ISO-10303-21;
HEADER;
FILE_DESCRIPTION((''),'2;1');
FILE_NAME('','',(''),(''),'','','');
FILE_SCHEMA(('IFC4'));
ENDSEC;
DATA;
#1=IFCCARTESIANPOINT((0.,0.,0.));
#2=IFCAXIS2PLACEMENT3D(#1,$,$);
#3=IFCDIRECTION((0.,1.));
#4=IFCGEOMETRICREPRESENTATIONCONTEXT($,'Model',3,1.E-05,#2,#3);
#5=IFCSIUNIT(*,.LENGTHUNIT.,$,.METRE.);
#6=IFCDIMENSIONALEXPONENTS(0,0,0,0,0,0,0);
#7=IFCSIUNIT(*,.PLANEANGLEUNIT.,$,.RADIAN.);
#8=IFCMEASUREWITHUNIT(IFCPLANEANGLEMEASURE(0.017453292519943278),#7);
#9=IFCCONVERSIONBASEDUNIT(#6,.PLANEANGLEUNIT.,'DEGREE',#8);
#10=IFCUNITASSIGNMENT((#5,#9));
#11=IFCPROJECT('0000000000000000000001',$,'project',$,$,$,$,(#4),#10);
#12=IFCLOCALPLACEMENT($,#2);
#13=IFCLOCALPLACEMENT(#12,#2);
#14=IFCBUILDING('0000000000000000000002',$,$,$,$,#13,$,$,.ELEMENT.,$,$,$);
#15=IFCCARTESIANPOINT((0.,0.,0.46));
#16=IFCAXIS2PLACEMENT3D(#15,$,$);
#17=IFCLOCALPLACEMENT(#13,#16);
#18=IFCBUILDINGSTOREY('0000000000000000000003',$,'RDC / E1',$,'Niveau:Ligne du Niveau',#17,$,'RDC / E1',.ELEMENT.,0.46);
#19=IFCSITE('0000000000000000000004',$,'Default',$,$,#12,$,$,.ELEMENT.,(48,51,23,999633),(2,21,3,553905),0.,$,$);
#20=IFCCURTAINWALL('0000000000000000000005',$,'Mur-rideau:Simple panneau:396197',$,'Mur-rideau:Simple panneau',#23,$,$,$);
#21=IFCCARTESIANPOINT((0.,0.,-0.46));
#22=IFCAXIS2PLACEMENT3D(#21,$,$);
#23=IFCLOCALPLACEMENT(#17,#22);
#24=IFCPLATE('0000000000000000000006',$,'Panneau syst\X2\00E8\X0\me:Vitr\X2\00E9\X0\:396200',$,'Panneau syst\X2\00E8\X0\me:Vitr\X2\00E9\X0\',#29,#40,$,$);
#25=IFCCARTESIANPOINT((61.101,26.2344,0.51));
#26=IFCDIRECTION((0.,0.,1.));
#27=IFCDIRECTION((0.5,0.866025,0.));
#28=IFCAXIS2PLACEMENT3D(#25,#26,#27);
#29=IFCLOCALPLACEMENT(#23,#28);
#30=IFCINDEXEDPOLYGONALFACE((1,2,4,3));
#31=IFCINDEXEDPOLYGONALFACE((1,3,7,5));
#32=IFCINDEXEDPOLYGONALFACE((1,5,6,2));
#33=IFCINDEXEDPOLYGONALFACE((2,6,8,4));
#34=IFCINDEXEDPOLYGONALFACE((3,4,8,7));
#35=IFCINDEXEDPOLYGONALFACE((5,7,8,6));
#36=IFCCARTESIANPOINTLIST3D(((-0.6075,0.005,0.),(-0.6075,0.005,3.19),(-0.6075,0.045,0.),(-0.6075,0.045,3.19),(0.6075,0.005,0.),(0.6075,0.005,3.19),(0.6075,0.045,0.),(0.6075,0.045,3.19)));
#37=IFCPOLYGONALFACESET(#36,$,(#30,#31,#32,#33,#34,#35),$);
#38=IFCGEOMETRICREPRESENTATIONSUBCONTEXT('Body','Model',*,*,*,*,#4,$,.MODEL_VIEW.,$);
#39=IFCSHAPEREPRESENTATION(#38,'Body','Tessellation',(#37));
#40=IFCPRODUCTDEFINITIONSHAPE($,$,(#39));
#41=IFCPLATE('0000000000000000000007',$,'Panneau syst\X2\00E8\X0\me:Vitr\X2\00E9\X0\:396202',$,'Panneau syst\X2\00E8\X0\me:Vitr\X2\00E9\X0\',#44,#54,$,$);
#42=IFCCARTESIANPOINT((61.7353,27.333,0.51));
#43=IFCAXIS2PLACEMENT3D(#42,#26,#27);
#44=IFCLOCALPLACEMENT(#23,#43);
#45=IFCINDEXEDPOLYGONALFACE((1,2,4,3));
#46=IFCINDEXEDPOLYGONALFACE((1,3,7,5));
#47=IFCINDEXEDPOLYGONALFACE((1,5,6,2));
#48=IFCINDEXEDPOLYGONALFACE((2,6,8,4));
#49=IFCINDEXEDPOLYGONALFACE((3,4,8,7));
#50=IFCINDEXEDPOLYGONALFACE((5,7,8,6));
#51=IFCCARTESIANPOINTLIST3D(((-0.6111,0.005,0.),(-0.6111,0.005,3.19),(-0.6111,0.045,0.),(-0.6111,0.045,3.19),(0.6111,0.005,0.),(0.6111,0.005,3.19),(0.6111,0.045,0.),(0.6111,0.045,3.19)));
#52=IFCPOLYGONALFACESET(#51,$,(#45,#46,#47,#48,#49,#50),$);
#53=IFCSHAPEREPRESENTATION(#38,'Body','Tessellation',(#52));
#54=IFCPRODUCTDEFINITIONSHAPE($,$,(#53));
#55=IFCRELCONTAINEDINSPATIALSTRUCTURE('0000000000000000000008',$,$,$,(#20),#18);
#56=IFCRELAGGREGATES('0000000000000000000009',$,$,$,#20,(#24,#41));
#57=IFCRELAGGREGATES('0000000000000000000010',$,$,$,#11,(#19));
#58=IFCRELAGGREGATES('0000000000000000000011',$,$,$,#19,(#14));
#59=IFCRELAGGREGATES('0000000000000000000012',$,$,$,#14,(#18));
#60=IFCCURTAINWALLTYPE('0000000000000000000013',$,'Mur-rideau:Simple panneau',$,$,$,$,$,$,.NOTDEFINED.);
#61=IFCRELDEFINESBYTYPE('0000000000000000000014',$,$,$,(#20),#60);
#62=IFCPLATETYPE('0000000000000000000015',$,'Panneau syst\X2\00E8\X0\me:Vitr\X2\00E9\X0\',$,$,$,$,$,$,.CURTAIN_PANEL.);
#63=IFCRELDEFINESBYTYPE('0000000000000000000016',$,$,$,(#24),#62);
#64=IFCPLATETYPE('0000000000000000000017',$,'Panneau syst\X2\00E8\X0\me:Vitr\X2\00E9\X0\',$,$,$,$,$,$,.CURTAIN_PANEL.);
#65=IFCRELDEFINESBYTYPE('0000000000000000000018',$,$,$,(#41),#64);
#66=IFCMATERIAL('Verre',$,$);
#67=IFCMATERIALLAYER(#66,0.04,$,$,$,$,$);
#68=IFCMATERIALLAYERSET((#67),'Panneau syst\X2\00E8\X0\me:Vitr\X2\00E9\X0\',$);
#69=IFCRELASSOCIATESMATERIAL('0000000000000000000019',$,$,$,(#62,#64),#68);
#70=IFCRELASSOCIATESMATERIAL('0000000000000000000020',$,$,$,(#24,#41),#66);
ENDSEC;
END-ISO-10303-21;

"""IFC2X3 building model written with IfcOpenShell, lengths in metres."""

from ifc_helpers import new_model, entity, si_unit, converted_unit, direction, frame, frame_2d, origin, place, context, subcontext, project, spatial, rectangle, extrude, source, transform, mapped, material, layer, layer_set, type_object, type_shapes, element, aggregate, save


model = new_model("IFC2X3")

# Units and contexts
model_context = context("Model", 3, precision=1e-05, world=origin(), true_north=direction((0.0, 1.0)))
body_context = subcontext(model_context, "Body", "Model", "MODEL_VIEW")
ifc_project = project(units=[si_unit("LENGTHUNIT", "METRE"), converted_unit("PLANEANGLEUNIT", "DEGREE", entity("IfcPlaneAngleMeasure", 0.017453292519943278), si_unit("PLANEANGLEUNIT", "RADIAN"), dimensions=[0, 0, 0, 0, 0, 0, 0])], contexts=[model_context])

# Site, building, storey
site_placement = place(None, origin())
site = spatial("IfcSite", under=ifc_project, at=site_placement, Name="Default", CompositionType="ELEMENT", RefLatitude=(48, 51, 23, 999633), RefLongitude=(2, 21, 3, 553905), RefElevation=0.0)
building_placement = place(site_placement, origin())
building = spatial("IfcBuilding", under=site, at=building_placement, CompositionType="ELEMENT")
storey_placement = place(building_placement, frame((0.0, 0.0, 0.46)))
storey = spatial("IfcBuildingStorey", under=building, at=storey_placement, Name="RDC / E1", ObjectType="Niveau:Ligne du Niveau", LongName="RDC / E1", CompositionType="ELEMENT", Elevation=0.46)

# Curtain wall
curtain_wall_type = type_object("IfcCurtainWallType", Name="Mur-rideau:Simple panneau", PredefinedType="NOTDEFINED")
curtain_wall_1_placement = place(storey_placement, frame((0.0, 0.0, -0.46)))
curtain_wall_1 = element("IfcCurtainWall", 1, at=curtain_wall_1_placement, inside=storey, type_object=curtain_wall_type, Name="Mur-rideau:Simple panneau:396197", ObjectType="Mur-rideau:Simple panneau")

# Plates
ifc_material_1 = material(Name="Verre")
ifc_layer_1 = layer(ifc_material_1, 0.04)
ifc_layer_set_1 = layer_set([ifc_layer_1], Name="Panneau système:Vitré")
plate_type_1 = type_object("IfcPlateType", Name="Panneau système:Vitré", PredefinedType="CURTAIN_PANEL", material=ifc_layer_set_1)
shared_shape_1 = source(origin(), body_context, "Body", "SweptSolid", [
    extrude(rectangle(XDim=0.04, YDim=1.215, at=frame_2d((0.0, 0.0), x_axis=(1.0, 0.0))), frame((0.0, 0.025, 0.0), z_axis=(0.0, 0.0, 1.0), x_axis=(0.0, 1.0, 0.0)), (0.0, 0.0, 1.0), 3.19),
])
type_shapes(plate_type_1, [shared_shape_1])
plate_1_placement = place(curtain_wall_1_placement, frame((61.101, 26.2344, 0.51), z_axis=(0.0, 0.0, 1.0), x_axis=(0.5, 0.866025, 0.0)))
plate_1 = element("IfcPlate", 2, at=plate_1_placement, type_object=plate_type_1, material=ifc_material_1, Name="Panneau système:Vitré:396200", ObjectType="Panneau système:Vitré", context=body_context, shape_type="MappedRepresentation", body=[
    mapped(shared_shape_1, transform((0.0, 0.0, 0.0), scale=1.0)),
])
plate_type_2 = type_object("IfcPlateType", Name="Panneau système:Vitré", PredefinedType="CURTAIN_PANEL", material=ifc_layer_set_1)
shared_shape_2 = source(origin(), body_context, "Body", "SweptSolid", [
    extrude(rectangle(XDim=0.04, YDim=1.2221, at=frame_2d((0.0, 0.0), x_axis=(1.0, 0.0))), frame((0.0, 0.025, 0.0), z_axis=(0.0, 0.0, 1.0), x_axis=(0.0, 1.0, 0.0)), (0.0, 0.0, 1.0), 3.19),
])
type_shapes(plate_type_2, [shared_shape_2])
plate_2_placement = place(curtain_wall_1_placement, frame((61.7353, 27.333, 0.51), z_axis=(0.0, 0.0, 1.0), x_axis=(0.5, 0.866025, 0.0)))
plate_2 = element("IfcPlate", 3, at=plate_2_placement, type_object=plate_type_2, material=ifc_material_1, Name="Panneau système:Vitré:396202", ObjectType="Panneau système:Vitré", context=body_context, shape_type="MappedRepresentation", body=[
    mapped(shared_shape_2, transform((0.0, 0.0, 0.0), scale=1.0)),
])
aggregate(curtain_wall_1, [plate_1, plate_2])

save(model, "model.ifc")
